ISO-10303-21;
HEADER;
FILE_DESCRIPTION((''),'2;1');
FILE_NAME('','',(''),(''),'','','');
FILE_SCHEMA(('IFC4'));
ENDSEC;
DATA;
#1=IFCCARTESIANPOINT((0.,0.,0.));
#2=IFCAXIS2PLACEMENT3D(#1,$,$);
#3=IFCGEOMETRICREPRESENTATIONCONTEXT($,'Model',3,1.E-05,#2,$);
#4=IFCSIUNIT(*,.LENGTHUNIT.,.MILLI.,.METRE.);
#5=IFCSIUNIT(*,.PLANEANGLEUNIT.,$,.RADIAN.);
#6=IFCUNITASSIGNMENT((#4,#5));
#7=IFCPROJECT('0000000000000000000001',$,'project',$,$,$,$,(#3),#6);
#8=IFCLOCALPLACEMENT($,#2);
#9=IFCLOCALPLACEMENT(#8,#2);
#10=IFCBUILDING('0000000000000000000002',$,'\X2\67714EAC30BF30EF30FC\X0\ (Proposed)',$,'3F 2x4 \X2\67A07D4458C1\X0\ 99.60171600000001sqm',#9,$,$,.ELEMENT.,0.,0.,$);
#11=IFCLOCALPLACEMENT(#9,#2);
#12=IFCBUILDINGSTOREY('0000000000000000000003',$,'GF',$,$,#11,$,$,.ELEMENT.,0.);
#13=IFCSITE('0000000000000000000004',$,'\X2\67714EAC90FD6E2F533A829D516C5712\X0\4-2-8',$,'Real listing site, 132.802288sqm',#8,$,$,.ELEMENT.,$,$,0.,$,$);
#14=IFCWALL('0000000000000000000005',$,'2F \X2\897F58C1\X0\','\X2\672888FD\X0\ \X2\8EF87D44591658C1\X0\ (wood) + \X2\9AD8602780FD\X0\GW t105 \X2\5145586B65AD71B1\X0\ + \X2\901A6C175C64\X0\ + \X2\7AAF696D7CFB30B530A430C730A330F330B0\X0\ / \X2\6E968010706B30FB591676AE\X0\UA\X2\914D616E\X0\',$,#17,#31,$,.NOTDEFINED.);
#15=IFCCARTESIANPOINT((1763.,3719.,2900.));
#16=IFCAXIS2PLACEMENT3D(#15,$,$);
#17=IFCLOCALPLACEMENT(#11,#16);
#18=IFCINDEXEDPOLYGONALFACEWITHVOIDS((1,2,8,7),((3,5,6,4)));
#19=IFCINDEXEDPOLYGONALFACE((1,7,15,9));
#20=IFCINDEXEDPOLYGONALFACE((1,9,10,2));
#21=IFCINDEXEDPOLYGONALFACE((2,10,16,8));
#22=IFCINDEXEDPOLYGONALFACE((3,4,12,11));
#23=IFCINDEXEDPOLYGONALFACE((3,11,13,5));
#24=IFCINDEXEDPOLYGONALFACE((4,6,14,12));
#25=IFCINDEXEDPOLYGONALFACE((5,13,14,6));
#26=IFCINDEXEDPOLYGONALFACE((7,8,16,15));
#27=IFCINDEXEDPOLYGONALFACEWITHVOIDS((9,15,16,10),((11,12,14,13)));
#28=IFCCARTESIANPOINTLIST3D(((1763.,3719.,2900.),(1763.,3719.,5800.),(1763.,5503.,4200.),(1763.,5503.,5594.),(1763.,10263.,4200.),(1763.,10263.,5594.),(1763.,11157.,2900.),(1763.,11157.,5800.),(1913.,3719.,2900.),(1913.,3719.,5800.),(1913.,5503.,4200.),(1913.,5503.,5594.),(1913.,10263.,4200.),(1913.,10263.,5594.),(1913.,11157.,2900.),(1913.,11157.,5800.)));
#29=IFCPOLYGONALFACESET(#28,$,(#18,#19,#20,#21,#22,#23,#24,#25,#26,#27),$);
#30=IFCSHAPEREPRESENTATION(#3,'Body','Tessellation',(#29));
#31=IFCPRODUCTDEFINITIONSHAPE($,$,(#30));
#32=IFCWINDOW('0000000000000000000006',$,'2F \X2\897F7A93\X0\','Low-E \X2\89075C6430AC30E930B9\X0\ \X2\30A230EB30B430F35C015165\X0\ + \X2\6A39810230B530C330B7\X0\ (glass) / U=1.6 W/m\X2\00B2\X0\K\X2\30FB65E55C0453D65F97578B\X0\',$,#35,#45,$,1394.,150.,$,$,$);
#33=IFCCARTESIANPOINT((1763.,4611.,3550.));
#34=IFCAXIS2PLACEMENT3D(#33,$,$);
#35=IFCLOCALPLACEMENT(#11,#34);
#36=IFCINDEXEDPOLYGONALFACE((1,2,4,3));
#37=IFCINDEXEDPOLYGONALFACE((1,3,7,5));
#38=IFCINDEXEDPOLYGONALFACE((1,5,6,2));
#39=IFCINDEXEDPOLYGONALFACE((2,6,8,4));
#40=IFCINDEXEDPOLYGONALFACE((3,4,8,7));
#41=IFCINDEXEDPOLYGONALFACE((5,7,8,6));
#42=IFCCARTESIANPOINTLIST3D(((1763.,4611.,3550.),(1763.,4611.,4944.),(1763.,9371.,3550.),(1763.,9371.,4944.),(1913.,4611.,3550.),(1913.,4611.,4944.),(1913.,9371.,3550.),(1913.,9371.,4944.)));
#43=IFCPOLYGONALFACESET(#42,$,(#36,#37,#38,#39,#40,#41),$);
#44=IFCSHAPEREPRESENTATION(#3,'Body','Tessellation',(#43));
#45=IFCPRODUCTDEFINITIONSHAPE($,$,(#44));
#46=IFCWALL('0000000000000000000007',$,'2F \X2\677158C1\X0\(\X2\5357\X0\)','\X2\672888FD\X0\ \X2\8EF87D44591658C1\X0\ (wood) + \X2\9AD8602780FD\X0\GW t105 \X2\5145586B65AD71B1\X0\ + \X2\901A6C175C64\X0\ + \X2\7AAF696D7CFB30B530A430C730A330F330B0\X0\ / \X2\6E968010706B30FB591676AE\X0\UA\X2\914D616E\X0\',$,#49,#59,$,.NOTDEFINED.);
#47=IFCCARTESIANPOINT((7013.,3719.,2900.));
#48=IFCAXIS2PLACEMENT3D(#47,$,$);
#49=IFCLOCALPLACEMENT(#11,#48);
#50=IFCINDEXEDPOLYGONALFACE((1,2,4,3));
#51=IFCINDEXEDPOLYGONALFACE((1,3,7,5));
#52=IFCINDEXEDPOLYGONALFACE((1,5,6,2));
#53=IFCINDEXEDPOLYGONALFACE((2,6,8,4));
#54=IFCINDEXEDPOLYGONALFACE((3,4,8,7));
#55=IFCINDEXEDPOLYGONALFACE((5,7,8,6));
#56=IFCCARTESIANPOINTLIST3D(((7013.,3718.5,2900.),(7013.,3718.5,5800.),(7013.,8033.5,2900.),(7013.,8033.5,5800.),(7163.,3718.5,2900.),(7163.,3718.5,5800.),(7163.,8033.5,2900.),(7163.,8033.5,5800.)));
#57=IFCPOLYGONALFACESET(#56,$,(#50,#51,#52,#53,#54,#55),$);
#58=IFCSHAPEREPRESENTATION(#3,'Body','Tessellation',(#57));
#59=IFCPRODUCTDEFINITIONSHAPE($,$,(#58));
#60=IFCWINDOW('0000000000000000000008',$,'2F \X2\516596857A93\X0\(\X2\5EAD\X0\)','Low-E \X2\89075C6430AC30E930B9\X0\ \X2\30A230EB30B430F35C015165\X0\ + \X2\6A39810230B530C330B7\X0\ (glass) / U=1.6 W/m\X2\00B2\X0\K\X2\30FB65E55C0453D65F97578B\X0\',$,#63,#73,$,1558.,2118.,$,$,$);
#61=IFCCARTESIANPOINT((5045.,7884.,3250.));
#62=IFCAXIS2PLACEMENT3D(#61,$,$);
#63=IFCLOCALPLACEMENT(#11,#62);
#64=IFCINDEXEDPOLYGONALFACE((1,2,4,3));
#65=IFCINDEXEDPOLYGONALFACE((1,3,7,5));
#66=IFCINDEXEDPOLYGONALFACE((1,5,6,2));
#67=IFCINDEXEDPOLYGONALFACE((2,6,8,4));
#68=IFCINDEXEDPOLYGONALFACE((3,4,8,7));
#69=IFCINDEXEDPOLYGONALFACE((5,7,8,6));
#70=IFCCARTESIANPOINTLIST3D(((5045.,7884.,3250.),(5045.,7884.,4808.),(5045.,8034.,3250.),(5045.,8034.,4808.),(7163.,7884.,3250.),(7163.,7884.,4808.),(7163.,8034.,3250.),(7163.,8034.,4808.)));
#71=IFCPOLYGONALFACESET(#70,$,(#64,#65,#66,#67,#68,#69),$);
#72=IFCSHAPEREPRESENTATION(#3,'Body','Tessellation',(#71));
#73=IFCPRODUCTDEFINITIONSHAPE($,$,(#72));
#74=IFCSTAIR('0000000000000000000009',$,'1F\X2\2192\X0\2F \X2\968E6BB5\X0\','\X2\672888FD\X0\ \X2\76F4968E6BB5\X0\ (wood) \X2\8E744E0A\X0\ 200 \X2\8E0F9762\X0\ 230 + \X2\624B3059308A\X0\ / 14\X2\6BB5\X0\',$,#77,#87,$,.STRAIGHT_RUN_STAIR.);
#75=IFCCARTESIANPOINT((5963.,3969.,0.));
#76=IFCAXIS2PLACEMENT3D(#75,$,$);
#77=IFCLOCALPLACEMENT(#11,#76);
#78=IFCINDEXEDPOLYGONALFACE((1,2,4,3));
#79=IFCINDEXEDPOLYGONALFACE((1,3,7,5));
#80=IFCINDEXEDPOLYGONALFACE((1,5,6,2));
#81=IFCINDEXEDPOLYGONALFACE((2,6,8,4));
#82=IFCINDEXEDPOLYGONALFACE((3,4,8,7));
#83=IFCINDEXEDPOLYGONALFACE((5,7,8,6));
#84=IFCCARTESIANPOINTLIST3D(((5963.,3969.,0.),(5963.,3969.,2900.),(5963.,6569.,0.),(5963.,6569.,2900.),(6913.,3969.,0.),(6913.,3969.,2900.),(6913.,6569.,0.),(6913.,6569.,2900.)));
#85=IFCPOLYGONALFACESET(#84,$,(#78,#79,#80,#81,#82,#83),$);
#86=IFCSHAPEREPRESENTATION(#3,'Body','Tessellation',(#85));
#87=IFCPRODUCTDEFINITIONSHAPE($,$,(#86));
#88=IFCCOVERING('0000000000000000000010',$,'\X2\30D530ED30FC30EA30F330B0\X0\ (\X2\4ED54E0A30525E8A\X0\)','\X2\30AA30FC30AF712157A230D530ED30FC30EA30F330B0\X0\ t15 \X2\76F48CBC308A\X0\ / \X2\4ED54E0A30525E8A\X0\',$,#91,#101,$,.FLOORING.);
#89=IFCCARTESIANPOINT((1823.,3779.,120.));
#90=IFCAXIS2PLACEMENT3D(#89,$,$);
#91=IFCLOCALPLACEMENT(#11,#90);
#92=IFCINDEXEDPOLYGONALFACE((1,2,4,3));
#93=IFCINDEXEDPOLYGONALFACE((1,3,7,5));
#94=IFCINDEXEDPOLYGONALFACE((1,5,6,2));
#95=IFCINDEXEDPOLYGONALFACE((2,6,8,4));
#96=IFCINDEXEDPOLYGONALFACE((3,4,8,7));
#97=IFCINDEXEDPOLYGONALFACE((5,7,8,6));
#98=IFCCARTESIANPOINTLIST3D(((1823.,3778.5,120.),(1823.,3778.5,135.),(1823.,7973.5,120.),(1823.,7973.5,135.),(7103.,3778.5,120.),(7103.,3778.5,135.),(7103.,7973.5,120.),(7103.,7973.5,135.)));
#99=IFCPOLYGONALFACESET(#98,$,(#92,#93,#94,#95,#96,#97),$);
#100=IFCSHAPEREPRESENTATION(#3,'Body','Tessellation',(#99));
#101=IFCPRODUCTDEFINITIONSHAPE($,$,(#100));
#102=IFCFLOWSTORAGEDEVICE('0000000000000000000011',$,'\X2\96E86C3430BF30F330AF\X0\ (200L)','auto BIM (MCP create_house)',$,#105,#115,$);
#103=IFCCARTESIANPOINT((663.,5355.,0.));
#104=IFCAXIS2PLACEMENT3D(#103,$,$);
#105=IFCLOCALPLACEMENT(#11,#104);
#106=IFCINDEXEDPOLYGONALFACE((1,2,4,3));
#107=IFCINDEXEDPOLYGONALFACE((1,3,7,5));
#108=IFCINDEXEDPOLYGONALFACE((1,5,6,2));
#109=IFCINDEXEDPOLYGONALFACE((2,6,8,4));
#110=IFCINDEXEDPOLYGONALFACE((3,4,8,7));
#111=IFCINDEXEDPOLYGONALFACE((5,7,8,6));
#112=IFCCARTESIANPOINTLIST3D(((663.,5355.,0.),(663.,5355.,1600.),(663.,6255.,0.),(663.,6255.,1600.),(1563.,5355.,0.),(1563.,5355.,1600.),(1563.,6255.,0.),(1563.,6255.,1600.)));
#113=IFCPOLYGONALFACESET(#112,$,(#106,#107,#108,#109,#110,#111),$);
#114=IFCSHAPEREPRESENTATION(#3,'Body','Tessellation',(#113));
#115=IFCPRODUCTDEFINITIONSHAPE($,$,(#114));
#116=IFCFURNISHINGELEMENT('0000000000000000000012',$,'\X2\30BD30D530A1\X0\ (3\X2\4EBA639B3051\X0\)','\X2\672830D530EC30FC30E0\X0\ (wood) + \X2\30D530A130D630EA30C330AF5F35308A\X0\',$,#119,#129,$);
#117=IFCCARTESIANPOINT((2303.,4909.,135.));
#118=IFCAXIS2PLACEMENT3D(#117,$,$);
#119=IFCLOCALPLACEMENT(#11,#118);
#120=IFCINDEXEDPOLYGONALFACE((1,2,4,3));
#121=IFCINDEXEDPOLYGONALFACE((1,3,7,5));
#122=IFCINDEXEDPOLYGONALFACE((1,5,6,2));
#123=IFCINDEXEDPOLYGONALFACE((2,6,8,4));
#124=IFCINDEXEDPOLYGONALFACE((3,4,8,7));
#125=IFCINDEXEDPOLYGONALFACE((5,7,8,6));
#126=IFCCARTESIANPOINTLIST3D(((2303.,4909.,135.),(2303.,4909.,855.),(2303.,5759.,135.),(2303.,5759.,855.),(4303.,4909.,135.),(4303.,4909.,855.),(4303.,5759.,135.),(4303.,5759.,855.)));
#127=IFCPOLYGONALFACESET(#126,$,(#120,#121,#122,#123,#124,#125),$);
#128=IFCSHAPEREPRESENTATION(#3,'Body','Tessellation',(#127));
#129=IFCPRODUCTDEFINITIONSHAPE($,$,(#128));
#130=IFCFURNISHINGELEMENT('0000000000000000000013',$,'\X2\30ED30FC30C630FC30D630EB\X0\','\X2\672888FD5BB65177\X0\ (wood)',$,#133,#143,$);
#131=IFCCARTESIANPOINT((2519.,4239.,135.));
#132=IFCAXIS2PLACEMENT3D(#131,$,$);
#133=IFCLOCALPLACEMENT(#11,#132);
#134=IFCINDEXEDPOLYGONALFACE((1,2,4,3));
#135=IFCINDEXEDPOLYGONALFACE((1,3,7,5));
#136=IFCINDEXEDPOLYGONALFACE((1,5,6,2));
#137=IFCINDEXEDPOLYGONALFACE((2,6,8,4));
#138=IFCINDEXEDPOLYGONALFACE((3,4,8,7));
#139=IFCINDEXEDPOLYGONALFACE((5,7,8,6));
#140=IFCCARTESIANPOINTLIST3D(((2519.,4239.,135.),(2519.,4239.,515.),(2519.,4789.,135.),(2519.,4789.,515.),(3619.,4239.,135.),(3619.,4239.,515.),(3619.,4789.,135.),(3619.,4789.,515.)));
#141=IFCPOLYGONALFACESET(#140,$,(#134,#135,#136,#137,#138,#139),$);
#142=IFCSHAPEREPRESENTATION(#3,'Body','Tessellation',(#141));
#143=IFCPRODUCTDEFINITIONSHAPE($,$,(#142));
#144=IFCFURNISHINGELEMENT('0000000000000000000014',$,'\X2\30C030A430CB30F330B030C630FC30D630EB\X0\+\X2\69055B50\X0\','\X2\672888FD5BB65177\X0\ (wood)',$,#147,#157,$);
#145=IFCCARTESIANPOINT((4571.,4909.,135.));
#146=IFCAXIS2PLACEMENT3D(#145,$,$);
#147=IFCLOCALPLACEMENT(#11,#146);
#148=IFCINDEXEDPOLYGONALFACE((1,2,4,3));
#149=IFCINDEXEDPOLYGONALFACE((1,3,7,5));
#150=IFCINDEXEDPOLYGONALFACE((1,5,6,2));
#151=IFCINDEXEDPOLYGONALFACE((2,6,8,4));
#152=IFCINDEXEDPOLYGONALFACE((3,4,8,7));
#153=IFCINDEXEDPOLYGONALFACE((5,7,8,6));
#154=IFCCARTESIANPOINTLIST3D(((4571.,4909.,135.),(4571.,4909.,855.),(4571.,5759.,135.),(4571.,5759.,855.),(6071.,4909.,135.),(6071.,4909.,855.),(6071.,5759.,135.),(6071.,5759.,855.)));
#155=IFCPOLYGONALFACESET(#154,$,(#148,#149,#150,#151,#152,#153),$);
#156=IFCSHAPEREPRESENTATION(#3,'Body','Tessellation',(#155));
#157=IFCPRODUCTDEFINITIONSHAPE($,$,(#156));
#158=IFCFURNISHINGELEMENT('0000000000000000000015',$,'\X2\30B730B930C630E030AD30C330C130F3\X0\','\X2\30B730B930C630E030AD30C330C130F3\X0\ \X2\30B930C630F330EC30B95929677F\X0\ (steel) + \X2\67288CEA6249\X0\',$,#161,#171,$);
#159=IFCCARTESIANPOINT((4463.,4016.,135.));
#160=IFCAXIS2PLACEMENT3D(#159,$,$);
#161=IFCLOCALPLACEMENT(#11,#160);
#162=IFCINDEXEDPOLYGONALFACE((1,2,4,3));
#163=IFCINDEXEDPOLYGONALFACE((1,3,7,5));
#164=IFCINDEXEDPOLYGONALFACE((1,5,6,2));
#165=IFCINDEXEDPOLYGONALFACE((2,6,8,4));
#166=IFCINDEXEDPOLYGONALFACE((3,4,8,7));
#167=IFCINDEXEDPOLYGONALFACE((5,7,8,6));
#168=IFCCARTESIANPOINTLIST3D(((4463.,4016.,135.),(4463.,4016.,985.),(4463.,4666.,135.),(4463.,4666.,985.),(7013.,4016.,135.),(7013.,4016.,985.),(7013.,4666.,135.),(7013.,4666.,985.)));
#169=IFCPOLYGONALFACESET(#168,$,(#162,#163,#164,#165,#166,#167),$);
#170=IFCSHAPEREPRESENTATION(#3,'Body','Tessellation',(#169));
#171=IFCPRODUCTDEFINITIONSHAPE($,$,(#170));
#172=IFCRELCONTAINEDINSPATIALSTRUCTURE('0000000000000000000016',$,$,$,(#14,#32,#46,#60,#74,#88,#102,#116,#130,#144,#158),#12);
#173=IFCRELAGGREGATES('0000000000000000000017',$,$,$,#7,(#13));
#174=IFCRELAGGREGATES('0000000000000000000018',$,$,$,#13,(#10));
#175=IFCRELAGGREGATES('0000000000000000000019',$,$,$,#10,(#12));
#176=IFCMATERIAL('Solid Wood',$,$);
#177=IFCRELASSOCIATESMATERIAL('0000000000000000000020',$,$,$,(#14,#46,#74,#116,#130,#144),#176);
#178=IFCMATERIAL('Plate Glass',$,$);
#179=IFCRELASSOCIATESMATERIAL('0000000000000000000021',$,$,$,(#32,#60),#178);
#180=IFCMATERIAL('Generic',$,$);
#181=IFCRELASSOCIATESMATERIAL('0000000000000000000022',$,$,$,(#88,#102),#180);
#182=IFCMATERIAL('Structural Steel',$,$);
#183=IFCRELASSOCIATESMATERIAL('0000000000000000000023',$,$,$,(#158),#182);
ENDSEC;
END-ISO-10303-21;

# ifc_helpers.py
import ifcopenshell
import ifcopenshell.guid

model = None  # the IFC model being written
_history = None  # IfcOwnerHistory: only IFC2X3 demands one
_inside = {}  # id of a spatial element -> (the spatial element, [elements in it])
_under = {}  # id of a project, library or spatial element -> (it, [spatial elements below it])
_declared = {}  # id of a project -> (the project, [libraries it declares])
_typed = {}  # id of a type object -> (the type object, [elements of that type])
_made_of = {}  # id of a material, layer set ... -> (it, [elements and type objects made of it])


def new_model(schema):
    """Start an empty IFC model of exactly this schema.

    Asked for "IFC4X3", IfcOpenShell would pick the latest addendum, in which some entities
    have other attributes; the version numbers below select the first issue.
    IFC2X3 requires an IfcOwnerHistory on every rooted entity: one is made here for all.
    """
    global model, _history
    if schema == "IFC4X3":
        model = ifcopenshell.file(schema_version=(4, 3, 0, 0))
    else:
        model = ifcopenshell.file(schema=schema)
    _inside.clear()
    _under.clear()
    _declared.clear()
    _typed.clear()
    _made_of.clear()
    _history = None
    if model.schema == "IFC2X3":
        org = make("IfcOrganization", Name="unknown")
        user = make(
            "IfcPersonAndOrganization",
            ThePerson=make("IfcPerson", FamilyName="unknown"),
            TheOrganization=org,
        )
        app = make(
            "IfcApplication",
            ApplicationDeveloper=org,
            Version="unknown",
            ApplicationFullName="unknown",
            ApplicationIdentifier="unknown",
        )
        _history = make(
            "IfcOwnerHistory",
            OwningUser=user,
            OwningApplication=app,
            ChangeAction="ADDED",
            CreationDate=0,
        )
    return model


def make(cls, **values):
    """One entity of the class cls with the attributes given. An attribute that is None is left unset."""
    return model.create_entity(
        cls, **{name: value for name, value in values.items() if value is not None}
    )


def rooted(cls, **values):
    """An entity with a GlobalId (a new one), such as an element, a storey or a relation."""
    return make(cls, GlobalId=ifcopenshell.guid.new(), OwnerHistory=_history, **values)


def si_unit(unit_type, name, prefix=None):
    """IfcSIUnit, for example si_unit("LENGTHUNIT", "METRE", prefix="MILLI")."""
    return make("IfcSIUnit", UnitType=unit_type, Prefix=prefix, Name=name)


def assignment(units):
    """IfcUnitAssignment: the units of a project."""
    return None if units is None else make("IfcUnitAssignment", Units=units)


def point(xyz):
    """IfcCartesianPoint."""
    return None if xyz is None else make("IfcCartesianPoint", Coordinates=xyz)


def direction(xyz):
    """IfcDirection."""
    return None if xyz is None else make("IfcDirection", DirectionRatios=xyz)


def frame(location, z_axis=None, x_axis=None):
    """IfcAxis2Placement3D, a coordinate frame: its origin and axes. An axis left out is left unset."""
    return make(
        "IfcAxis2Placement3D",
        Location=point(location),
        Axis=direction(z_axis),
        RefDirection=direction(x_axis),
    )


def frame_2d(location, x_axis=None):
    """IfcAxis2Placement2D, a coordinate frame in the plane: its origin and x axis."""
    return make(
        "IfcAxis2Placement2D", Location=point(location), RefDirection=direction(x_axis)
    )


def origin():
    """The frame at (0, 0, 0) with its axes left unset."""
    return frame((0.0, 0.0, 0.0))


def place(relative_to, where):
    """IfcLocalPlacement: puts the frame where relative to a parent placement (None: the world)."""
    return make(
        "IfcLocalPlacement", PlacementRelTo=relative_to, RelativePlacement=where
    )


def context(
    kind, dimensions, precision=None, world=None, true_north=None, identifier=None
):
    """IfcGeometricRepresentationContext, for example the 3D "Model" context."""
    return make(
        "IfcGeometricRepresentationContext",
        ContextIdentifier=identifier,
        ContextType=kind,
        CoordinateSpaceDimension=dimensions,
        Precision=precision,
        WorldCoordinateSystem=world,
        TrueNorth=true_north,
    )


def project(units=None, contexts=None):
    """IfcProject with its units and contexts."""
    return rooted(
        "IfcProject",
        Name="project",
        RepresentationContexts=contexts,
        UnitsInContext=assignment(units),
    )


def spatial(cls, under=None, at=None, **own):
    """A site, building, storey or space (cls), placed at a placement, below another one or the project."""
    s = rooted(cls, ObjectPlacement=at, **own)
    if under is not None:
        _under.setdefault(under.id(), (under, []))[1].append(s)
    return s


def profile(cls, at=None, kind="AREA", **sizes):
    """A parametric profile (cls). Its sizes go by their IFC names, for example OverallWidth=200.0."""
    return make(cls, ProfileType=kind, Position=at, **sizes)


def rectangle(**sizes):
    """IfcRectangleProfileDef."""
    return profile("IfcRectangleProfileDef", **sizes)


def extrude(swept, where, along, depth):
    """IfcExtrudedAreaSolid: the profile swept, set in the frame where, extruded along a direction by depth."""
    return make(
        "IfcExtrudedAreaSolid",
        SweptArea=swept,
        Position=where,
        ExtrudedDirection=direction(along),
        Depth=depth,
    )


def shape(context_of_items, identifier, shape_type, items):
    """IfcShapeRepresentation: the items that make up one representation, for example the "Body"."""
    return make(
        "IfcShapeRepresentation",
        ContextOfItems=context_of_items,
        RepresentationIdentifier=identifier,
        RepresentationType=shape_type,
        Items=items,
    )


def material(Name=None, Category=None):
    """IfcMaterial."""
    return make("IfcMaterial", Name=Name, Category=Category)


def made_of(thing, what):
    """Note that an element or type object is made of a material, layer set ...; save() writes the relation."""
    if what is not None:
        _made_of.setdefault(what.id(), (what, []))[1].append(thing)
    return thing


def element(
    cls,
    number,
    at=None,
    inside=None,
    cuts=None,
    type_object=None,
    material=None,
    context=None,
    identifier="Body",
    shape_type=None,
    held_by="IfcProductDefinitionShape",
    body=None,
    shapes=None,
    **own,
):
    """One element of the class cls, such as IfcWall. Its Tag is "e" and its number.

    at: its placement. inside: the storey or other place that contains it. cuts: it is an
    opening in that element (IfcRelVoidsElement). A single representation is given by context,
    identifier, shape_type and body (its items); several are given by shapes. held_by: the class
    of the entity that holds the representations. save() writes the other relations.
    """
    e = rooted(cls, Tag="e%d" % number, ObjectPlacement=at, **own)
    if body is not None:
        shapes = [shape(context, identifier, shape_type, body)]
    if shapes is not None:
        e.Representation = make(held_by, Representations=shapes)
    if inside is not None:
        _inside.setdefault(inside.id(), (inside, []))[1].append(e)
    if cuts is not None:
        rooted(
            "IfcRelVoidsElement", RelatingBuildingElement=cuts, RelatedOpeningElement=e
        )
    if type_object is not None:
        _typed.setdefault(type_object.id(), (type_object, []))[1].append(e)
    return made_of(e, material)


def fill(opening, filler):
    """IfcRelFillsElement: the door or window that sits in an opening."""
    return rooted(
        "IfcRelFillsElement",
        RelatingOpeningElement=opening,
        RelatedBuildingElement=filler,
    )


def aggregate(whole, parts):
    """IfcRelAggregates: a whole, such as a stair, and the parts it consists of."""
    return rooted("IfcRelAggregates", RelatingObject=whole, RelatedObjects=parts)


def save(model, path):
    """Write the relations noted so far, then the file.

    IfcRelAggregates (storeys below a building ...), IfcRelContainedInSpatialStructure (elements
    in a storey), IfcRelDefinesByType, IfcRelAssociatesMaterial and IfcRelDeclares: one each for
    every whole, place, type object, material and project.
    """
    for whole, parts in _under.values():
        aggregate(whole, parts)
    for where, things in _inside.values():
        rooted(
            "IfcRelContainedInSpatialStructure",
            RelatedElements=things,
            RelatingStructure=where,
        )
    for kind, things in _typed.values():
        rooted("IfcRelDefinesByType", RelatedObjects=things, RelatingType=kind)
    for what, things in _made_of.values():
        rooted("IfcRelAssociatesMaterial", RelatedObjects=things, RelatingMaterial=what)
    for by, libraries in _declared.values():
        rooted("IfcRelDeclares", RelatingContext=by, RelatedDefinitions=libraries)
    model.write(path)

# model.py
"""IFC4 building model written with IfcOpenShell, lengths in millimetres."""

from ifc_helpers import new_model, si_unit, frame, frame_2d, origin, place, context, project, spatial, rectangle, extrude, material, element, fill, save


model = new_model("IFC4")

# Units and contexts
model_context = context("Model", 3, precision=1e-05, world=origin())
ifc_project = project(units=[si_unit("LENGTHUNIT", "METRE", prefix="MILLI"), si_unit("PLANEANGLEUNIT", "RADIAN")], contexts=[model_context])

# Site, building, storey
site_placement = place(None, origin())
site = spatial("IfcSite", under=ifc_project, at=site_placement, Name="東京都港区芝公園4-2-8", ObjectType="Real listing site, 132.802288sqm", CompositionType="ELEMENT", RefElevation=0.0)
building_placement = place(site_placement, origin())
building = spatial("IfcBuilding", under=site, at=building_placement, Name="東京タワー (Proposed)", ObjectType="3F 2x4 枠組壁 99.60171600000001sqm", CompositionType="ELEMENT", ElevationOfRefHeight=0.0, ElevationOfTerrain=0.0)
storey_placement = place(building_placement, origin())
storey = spatial("IfcBuildingStorey", under=building, at=storey_placement, Name="GF", CompositionType="ELEMENT", Elevation=0.0)

# Shared definitions
ifc_material_1 = material(Name="Solid Wood")

# Shared definitions
ifc_material_2 = material(Name="Plate Glass")

# Walls, openings, windows
wall_1_placement = place(storey_placement, frame((1763.0, 3719.0, 2900.0)))
wall_1 = element("IfcWall", 1, at=wall_1_placement, inside=storey, material=ifc_material_1, Name="2F 西壁", Description="木製 軸組外壁 (wood) + 高性能GW t105 充填断熱 + 通気層 + 窯業系サイディング / 準耐火・外皮UA配慮", PredefinedType="NOTDEFINED", context=model_context, shape_type="SweptSolid", body=[
    extrude(rectangle(XDim=150.0, YDim=7438.0, at=frame_2d((75.0, 3719.0))), frame((1763.0, 3719.0, 2900.0)), (0.0, 0.0, 1.0), 2900.0),
])
opening_1_placement = place(storey_placement, frame((1763.0, 4611.0, 3550.0)))
opening_1 = element("IfcOpeningElement", 2, at=opening_1_placement, cuts=wall_1, PredefinedType="NOTDEFINED", context=model_context, shape_type="SweptSolid", body=[
    extrude(rectangle(XDim=150.0, YDim=4760.0, at=frame_2d((75.0, 2380.0))), frame((1763.0, 4611.0, 3550.0)), (0.0, 0.0, 1.0), 1394.0),
])
window_1_placement = place(storey_placement, frame((1763.0, 4611.0, 3550.0)))
window_1 = element("IfcWindow", 3, at=window_1_placement, inside=storey, material=ifc_material_2, Name="2F 西窓", Description="Low-E 複層ガラス アルゴン封入 + 樹脂サッシ (glass) / U=1.6 W/m²K・日射取得型", OverallHeight=1394.0, OverallWidth=150.0, context=model_context, shape_type="SweptSolid", body=[
    extrude(rectangle(XDim=150.0, YDim=4760.0, at=frame_2d((75.0, 2380.0))), frame((1763.0, 4611.0, 3550.0)), (0.0, 0.0, 1.0), 1394.0),
])
fill(opening_1, window_1)
wall_2_placement = place(storey_placement, frame((7013.0, 3719.0, 2900.0)))
wall_2 = element("IfcWall", 4, at=wall_2_placement, inside=storey, material=ifc_material_1, Name="2F 東壁(南)", Description="木製 軸組外壁 (wood) + 高性能GW t105 充填断熱 + 通気層 + 窯業系サイディング / 準耐火・外皮UA配慮", PredefinedType="NOTDEFINED", context=model_context, shape_type="SweptSolid", body=[
    extrude(rectangle(XDim=150.0, YDim=4315.0, at=frame_2d((75.0, 2157.0))), frame((7013.0, 3719.0, 2900.0)), (0.0, 0.0, 1.0), 2900.0),
])
opening_2_placement = place(storey_placement, frame((5045.0, 7884.0, 3250.0)))
opening_2 = element("IfcOpeningElement", 5, at=opening_2_placement, cuts=wall_2, PredefinedType="NOTDEFINED", context=model_context, shape_type="SweptSolid", body=[
    extrude(rectangle(XDim=2118.0, YDim=150.0, at=frame_2d((1059.0, 75.0))), frame((5045.0, 7884.0, 3250.0)), (0.0, 0.0, 1.0), 1558.0),
])
window_2_placement = place(storey_placement, frame((5045.0, 7884.0, 3250.0)))
window_2 = element("IfcWindow", 6, at=window_2_placement, inside=storey, material=ifc_material_2, Name="2F 入隅窓(庭)", Description="Low-E 複層ガラス アルゴン封入 + 樹脂サッシ (glass) / U=1.6 W/m²K・日射取得型", OverallHeight=1558.0, OverallWidth=2118.0, context=model_context, shape_type="SweptSolid", body=[
    extrude(rectangle(XDim=2118.0, YDim=150.0, at=frame_2d((1059.0, 75.0))), frame((5045.0, 7884.0, 3250.0)), (0.0, 0.0, 1.0), 1558.0),
])
fill(opening_2, window_2)

# Stair
stair_placement = place(storey_placement, frame((5963.0, 3969.0, 0.0)))
element("IfcStair", 7, at=stair_placement, inside=storey, material=ifc_material_1, Name="1F→2F 階段", Description="木製 直階段 (wood) 蹴上 200 踏面 230 + 手すり / 14段", PredefinedType="STRAIGHT_RUN_STAIR", context=model_context, shape_type="SweptSolid", body=[
    extrude(rectangle(XDim=950.0, YDim=2600.0, at=frame_2d((475.0, 1300.0))), frame((5963.0, 3969.0, 0.0)), (0.0, 0.0, 1.0), 2900.0),
])

# Covering
ifc_material_3 = material(Name="Generic")
covering_placement = place(storey_placement, frame((1823.0, 3779.0, 120.0)))
element("IfcCovering", 8, at=covering_placement, inside=storey, material=ifc_material_3, Name="フローリング (仕上げ床)", Description="オーク無垢フローリング t15 直貼り / 仕上げ床", PredefinedType="FLOORING", context=model_context, shape_type="SweptSolid", body=[
    extrude(rectangle(XDim=5280.0, YDim=4195.0, at=frame_2d((2640.0, 2097.0))), frame((1823.0, 3779.0, 120.0)), (0.0, 0.0, 1.0), 15.0),
])

# Flow storage device
flow_storage_device_placement = place(storey_placement, frame((663.0, 5355.0, 0.0)))
element("IfcFlowStorageDevice", 9, at=flow_storage_device_placement, inside=storey, material=ifc_material_3, Name="雨水タンク (200L)", Description="auto BIM (MCP create_house)", context=model_context, shape_type="SweptSolid", body=[
    extrude(rectangle(XDim=900.0, YDim=900.0, at=frame_2d((450.0, 450.0))), frame((663.0, 5355.0, 0.0)), (0.0, 0.0, 1.0), 1600.0),
])

# Furnishing elements
furnishing_1_placement = place(storey_placement, frame((2303.0, 4909.0, 135.0)))
element("IfcFurnishingElement", 10, at=furnishing_1_placement, inside=storey, material=ifc_material_1, Name="ソファ (3人掛け)", Description="木フレーム (wood) + ファブリック張り", context=model_context, shape_type="SweptSolid", body=[
    extrude(rectangle(XDim=2000.0, YDim=850.0, at=frame_2d((1000.0, 425.0))), frame((2303.0, 4909.0, 135.0)), (0.0, 0.0, 1.0), 720.0),
])
furnishing_2_placement = place(storey_placement, frame((2519.0, 4239.0, 135.0)))
element("IfcFurnishingElement", 11, at=furnishing_2_placement, inside=storey, material=ifc_material_1, Name="ローテーブル", Description="木製家具 (wood)", context=model_context, shape_type="SweptSolid", body=[
    extrude(rectangle(XDim=1100.0, YDim=550.0, at=frame_2d((550.0, 275.0))), frame((2519.0, 4239.0, 135.0)), (0.0, 0.0, 1.0), 380.0),
])
furnishing_3_placement = place(storey_placement, frame((4571.0, 4909.0, 135.0)))
element("IfcFurnishingElement", 12, at=furnishing_3_placement, inside=storey, material=ifc_material_1, Name="ダイニングテーブル+椅子", Description="木製家具 (wood)", context=model_context, shape_type="SweptSolid", body=[
    extrude(rectangle(XDim=1500.0, YDim=850.0, at=frame_2d((750.0, 425.0))), frame((4571.0, 4909.0, 135.0)), (0.0, 0.0, 1.0), 720.0),
])
ifc_material_4 = material(Name="Structural Steel")
furnishing_4_placement = place(storey_placement, frame((4463.0, 4016.0, 135.0)))
element("IfcFurnishingElement", 13, at=furnishing_4_placement, inside=storey, material=ifc_material_4, Name="システムキッチン", Description="システムキッチン ステンレス天板 (steel) + 木質扉", context=model_context, shape_type="SweptSolid", body=[
    extrude(rectangle(XDim=2550.0, YDim=650.0, at=frame_2d((1275.0, 325.0))), frame((4463.0, 4016.0, 135.0)), (0.0, 0.0, 1.0), 850.0),
])

save(model, "model.ifc")
